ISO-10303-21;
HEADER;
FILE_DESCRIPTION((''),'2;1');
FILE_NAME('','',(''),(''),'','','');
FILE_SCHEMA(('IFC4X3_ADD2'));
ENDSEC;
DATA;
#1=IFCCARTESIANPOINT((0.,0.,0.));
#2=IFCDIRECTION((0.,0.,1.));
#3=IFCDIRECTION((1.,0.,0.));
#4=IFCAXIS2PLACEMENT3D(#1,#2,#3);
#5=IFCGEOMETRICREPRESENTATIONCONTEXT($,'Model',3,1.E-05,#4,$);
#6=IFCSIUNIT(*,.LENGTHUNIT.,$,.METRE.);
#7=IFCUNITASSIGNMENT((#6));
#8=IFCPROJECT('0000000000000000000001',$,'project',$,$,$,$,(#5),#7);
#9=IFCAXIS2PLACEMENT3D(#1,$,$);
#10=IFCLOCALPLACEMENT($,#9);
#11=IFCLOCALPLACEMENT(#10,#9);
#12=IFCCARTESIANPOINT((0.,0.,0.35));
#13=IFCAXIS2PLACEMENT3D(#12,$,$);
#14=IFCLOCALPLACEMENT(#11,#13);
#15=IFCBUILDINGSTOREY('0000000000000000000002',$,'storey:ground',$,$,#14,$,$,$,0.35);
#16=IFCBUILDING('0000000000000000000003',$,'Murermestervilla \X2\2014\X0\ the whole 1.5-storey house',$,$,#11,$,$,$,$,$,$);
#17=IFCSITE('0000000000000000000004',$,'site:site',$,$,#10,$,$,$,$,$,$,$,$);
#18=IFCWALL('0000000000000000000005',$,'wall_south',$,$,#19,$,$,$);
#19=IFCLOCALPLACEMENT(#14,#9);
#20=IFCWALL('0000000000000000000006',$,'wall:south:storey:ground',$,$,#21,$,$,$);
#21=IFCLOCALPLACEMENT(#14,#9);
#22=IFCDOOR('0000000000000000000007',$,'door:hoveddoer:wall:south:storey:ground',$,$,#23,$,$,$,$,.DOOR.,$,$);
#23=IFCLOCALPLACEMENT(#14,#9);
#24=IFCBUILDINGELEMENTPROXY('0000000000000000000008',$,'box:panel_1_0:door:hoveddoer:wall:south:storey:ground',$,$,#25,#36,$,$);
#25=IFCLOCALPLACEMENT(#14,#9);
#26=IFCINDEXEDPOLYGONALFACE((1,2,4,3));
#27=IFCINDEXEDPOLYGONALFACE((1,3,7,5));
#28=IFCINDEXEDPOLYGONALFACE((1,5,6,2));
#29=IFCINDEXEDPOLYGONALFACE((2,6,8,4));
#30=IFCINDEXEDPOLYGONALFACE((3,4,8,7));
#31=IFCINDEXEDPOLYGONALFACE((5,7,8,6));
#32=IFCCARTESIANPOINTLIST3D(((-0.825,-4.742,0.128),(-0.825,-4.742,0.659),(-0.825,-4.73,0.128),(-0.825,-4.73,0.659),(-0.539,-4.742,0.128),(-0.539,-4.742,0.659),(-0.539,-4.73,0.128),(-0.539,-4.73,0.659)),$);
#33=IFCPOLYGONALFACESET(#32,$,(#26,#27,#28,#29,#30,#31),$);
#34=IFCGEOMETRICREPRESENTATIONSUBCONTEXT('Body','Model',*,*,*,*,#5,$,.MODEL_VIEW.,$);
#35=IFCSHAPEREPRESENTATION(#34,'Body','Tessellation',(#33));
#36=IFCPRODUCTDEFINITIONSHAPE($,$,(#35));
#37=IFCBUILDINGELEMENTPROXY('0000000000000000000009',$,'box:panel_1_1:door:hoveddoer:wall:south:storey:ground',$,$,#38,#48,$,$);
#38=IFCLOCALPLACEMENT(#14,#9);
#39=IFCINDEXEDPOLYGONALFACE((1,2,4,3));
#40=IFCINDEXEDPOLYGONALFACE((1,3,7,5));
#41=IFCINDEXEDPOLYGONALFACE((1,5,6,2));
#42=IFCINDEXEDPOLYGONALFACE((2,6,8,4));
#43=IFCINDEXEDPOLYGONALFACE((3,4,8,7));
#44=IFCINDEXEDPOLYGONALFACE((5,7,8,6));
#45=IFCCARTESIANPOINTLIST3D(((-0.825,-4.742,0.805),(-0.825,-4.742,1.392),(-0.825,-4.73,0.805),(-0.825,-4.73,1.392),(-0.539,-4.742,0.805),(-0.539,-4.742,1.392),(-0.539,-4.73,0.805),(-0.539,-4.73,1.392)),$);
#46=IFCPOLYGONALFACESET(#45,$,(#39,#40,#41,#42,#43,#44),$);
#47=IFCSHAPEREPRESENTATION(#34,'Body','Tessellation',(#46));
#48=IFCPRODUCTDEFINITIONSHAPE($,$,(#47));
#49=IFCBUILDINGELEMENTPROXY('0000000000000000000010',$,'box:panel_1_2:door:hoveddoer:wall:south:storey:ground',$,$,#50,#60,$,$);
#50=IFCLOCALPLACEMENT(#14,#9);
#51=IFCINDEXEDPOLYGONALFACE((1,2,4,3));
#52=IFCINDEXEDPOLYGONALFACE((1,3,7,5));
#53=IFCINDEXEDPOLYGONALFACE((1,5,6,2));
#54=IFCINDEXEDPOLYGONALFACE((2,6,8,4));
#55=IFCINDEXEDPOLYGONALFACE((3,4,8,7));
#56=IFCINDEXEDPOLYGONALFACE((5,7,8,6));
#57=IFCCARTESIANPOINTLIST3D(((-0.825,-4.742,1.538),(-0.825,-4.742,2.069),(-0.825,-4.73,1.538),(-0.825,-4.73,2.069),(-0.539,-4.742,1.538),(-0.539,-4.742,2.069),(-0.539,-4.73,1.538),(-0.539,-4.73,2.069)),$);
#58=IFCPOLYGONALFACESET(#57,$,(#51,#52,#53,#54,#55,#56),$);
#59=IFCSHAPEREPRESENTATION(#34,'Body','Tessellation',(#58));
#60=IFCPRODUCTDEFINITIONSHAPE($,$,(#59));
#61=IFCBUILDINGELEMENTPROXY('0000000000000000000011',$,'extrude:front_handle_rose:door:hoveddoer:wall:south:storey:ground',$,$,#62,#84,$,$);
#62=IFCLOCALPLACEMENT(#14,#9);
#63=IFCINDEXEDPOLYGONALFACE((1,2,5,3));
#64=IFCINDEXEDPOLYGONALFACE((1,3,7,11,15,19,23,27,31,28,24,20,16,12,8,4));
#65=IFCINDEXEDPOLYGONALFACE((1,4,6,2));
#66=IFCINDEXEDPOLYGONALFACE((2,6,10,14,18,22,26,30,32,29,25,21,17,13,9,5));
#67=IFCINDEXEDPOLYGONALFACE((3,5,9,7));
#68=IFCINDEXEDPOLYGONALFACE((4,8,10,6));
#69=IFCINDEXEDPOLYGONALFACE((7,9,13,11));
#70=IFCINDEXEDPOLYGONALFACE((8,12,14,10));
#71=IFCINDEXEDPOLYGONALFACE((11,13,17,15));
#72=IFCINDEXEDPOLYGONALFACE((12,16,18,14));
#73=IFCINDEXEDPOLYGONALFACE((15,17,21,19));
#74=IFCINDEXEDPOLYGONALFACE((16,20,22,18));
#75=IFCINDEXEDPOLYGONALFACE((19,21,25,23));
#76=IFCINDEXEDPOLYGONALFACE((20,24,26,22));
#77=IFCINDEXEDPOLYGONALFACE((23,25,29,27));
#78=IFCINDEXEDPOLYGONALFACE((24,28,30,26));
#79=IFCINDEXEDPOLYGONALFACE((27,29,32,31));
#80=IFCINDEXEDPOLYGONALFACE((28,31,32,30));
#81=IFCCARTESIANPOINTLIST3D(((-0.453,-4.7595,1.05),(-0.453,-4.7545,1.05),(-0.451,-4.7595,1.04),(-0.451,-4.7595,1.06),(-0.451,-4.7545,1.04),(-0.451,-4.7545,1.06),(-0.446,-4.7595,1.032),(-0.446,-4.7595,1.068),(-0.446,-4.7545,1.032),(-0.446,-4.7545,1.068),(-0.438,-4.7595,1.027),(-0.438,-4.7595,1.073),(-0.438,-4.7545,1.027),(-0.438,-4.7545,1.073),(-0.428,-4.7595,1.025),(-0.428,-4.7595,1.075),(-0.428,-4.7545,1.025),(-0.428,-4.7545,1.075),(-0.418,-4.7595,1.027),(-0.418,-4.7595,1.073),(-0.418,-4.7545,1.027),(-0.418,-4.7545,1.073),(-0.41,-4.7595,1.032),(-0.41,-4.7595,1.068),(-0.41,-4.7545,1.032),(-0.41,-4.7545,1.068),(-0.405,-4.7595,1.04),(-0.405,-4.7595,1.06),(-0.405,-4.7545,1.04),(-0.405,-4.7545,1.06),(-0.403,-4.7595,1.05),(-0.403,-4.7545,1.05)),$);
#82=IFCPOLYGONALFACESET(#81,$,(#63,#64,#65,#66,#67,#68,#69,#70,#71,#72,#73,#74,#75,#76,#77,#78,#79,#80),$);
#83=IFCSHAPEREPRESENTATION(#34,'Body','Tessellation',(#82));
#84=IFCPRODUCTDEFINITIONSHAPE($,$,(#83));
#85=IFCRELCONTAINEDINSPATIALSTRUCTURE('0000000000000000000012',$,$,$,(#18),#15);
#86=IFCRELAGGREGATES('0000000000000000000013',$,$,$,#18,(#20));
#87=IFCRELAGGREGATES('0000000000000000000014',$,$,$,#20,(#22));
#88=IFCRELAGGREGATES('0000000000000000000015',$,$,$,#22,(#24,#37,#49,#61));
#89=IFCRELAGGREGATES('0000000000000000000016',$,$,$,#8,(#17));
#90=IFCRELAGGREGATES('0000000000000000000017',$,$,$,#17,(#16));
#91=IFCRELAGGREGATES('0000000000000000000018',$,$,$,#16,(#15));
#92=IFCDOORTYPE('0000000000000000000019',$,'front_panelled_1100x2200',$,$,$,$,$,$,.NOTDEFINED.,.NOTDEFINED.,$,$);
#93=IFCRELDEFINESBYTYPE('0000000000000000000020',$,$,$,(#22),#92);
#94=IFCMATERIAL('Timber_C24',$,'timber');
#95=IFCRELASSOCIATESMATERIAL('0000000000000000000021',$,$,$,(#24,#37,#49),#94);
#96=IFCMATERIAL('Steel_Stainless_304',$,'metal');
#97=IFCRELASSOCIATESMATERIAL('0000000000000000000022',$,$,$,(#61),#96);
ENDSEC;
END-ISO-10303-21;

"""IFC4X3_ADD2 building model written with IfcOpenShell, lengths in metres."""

from ifc_helpers import new_model, si_unit, frame, origin, origin_with_axes, place, context, subcontext, project, spatial, polyline, rectangle, outline, extrude, source, transform, mapped, material, type_object, element, aggregate, save


model = new_model("IFC4X3_ADD2")

# Units and contexts
model_context = context("Model", 3, precision=1e-05, world=origin_with_axes())
body_context = subcontext(model_context, "Body", "Model", "MODEL_VIEW")
ifc_project = project(units=[si_unit("LENGTHUNIT", "METRE")], contexts=[model_context])

# Site, building, storey
placement = place(None, origin())
site = spatial("IfcSite", under=ifc_project, at=placement, Name="site:site")
building_placement = place(placement, origin())
building = spatial("IfcBuilding", under=site, at=building_placement, Name="Murermestervilla — the whole 1.5-storey house")
storey_placement = place(building_placement, frame((0.0, 0.0, 0.35)))
storey = spatial("IfcBuildingStorey", under=building, at=storey_placement, Name="storey:ground", Elevation=0.35)

# Walls, door, building element proxies
wall_1_placement = place(storey_placement, origin())
wall_1 = element("IfcWall", 1, at=wall_1_placement, inside=storey, Name="wall_south")
wall_2_placement = place(wall_1_placement, frame((0.0, 0.0, -0.35)))
wall_2 = element("IfcWall", 2, at=wall_2_placement, Name="wall:south:storey:ground")
aggregate(wall_1, [wall_2])
door_type = type_object("IfcDoorType", Name="front_panelled_1100x2200", OperationType="NOTDEFINED", PredefinedType="NOTDEFINED")
door_placement = place(None, frame((-0.888, -4.828, 0.35)))
door = element("IfcDoor", 3, at=door_placement, type_object=door_type, Name="door:hoveddoer:wall:south:storey:ground", PredefinedType="DOOR")
aggregate(wall_2, [door])
ifc_material_1 = material(Name="Steel_Stainless_304", Category="metal")
ifc_material_2 = material(Name="Timber_C24", Category="timber")
shared_shape_1 = source(origin(), body_context, "Body", "SweptSolid", [
    extrude(rectangle(XDim=0.286, YDim=0.012), frame((0.0, 0.0, -0.2655)), (0.0, 0.0, 1.0), 0.531),
])
proxy_1_placement = place(None, frame((-0.682, -4.736, 0.7435)))
proxy_1 = element("IfcBuildingElementProxy", 4, at=proxy_1_placement, material=ifc_material_2, Name="box:panel_1_0:door:hoveddoer:wall:south:storey:ground", context=body_context, shape_type="MappedRepresentation", body=[
    mapped(shared_shape_1, transform((0.0, 0.0, 0.0))),
])
shared_shape_2 = source(origin(), body_context, "Body", "SweptSolid", [
    extrude(rectangle(XDim=0.286, YDim=0.012), frame((0.0, 0.0, -0.2935)), (0.0, 0.0, 1.0), 0.587),
])
proxy_2_placement = place(None, frame((-0.682, -4.736, 1.4485)))
proxy_2 = element("IfcBuildingElementProxy", 5, at=proxy_2_placement, material=ifc_material_2, Name="box:panel_1_1:door:hoveddoer:wall:south:storey:ground", context=body_context, shape_type="MappedRepresentation", body=[
    mapped(shared_shape_2, transform((0.0, 0.0, 0.0))),
])
shared_shape_3 = source(origin(), body_context, "Body", "SweptSolid", [
    extrude(rectangle(XDim=0.286, YDim=0.012), frame((0.0, 0.0, -0.2655)), (0.0, 0.0, 1.0), 0.531),
])
proxy_3_placement = place(None, frame((-0.682, -4.736, 2.1535)))
proxy_3 = element("IfcBuildingElementProxy", 6, at=proxy_3_placement, material=ifc_material_2, Name="box:panel_1_2:door:hoveddoer:wall:south:storey:ground", context=body_context, shape_type="MappedRepresentation", body=[
    mapped(shared_shape_3, transform((0.0, 0.0, 0.0))),
])
shared_shape_4 = source(origin(), body_context, "Body", "SweptSolid", [
    extrude(outline(polyline([(-0.0049, -0.0245), (0.0053, -0.0245), (0.0141, -0.0212), (0.0206, -0.0143), (0.0245, -0.0049), (0.0245, 0.0053), (0.0212, 0.0141), (0.0143, 0.0206), (0.0049, 0.0245), (-0.0053, 0.0245), (-0.0141, 0.0212), (-0.0206, 0.0143), (-0.0245, 0.0049), (-0.0245, -0.0053), (-0.0212, -0.0141), (-0.0143, -0.0206), (-0.0049, -0.0245)])), frame((0.0, 0.0, -0.0025)), (0.0, 0.0, 1.0), 0.005),
])
proxy_4_placement = place(None, frame((-0.428, -4.757, 1.4), z_axis=(0.0, -1.0, 0.0), x_axis=(-0.196116, 0.0, 0.980581)))
proxy_4 = element("IfcBuildingElementProxy", 7, at=proxy_4_placement, material=ifc_material_1, Name="extrude:front_handle_rose:door:hoveddoer:wall:south:storey:ground", context=body_context, shape_type="MappedRepresentation", body=[
    mapped(shared_shape_4, transform((0.0, 0.0, 0.0))),
])
aggregate(door, [proxy_1, proxy_2, proxy_3, proxy_4])

save(model, "model.ifc")
